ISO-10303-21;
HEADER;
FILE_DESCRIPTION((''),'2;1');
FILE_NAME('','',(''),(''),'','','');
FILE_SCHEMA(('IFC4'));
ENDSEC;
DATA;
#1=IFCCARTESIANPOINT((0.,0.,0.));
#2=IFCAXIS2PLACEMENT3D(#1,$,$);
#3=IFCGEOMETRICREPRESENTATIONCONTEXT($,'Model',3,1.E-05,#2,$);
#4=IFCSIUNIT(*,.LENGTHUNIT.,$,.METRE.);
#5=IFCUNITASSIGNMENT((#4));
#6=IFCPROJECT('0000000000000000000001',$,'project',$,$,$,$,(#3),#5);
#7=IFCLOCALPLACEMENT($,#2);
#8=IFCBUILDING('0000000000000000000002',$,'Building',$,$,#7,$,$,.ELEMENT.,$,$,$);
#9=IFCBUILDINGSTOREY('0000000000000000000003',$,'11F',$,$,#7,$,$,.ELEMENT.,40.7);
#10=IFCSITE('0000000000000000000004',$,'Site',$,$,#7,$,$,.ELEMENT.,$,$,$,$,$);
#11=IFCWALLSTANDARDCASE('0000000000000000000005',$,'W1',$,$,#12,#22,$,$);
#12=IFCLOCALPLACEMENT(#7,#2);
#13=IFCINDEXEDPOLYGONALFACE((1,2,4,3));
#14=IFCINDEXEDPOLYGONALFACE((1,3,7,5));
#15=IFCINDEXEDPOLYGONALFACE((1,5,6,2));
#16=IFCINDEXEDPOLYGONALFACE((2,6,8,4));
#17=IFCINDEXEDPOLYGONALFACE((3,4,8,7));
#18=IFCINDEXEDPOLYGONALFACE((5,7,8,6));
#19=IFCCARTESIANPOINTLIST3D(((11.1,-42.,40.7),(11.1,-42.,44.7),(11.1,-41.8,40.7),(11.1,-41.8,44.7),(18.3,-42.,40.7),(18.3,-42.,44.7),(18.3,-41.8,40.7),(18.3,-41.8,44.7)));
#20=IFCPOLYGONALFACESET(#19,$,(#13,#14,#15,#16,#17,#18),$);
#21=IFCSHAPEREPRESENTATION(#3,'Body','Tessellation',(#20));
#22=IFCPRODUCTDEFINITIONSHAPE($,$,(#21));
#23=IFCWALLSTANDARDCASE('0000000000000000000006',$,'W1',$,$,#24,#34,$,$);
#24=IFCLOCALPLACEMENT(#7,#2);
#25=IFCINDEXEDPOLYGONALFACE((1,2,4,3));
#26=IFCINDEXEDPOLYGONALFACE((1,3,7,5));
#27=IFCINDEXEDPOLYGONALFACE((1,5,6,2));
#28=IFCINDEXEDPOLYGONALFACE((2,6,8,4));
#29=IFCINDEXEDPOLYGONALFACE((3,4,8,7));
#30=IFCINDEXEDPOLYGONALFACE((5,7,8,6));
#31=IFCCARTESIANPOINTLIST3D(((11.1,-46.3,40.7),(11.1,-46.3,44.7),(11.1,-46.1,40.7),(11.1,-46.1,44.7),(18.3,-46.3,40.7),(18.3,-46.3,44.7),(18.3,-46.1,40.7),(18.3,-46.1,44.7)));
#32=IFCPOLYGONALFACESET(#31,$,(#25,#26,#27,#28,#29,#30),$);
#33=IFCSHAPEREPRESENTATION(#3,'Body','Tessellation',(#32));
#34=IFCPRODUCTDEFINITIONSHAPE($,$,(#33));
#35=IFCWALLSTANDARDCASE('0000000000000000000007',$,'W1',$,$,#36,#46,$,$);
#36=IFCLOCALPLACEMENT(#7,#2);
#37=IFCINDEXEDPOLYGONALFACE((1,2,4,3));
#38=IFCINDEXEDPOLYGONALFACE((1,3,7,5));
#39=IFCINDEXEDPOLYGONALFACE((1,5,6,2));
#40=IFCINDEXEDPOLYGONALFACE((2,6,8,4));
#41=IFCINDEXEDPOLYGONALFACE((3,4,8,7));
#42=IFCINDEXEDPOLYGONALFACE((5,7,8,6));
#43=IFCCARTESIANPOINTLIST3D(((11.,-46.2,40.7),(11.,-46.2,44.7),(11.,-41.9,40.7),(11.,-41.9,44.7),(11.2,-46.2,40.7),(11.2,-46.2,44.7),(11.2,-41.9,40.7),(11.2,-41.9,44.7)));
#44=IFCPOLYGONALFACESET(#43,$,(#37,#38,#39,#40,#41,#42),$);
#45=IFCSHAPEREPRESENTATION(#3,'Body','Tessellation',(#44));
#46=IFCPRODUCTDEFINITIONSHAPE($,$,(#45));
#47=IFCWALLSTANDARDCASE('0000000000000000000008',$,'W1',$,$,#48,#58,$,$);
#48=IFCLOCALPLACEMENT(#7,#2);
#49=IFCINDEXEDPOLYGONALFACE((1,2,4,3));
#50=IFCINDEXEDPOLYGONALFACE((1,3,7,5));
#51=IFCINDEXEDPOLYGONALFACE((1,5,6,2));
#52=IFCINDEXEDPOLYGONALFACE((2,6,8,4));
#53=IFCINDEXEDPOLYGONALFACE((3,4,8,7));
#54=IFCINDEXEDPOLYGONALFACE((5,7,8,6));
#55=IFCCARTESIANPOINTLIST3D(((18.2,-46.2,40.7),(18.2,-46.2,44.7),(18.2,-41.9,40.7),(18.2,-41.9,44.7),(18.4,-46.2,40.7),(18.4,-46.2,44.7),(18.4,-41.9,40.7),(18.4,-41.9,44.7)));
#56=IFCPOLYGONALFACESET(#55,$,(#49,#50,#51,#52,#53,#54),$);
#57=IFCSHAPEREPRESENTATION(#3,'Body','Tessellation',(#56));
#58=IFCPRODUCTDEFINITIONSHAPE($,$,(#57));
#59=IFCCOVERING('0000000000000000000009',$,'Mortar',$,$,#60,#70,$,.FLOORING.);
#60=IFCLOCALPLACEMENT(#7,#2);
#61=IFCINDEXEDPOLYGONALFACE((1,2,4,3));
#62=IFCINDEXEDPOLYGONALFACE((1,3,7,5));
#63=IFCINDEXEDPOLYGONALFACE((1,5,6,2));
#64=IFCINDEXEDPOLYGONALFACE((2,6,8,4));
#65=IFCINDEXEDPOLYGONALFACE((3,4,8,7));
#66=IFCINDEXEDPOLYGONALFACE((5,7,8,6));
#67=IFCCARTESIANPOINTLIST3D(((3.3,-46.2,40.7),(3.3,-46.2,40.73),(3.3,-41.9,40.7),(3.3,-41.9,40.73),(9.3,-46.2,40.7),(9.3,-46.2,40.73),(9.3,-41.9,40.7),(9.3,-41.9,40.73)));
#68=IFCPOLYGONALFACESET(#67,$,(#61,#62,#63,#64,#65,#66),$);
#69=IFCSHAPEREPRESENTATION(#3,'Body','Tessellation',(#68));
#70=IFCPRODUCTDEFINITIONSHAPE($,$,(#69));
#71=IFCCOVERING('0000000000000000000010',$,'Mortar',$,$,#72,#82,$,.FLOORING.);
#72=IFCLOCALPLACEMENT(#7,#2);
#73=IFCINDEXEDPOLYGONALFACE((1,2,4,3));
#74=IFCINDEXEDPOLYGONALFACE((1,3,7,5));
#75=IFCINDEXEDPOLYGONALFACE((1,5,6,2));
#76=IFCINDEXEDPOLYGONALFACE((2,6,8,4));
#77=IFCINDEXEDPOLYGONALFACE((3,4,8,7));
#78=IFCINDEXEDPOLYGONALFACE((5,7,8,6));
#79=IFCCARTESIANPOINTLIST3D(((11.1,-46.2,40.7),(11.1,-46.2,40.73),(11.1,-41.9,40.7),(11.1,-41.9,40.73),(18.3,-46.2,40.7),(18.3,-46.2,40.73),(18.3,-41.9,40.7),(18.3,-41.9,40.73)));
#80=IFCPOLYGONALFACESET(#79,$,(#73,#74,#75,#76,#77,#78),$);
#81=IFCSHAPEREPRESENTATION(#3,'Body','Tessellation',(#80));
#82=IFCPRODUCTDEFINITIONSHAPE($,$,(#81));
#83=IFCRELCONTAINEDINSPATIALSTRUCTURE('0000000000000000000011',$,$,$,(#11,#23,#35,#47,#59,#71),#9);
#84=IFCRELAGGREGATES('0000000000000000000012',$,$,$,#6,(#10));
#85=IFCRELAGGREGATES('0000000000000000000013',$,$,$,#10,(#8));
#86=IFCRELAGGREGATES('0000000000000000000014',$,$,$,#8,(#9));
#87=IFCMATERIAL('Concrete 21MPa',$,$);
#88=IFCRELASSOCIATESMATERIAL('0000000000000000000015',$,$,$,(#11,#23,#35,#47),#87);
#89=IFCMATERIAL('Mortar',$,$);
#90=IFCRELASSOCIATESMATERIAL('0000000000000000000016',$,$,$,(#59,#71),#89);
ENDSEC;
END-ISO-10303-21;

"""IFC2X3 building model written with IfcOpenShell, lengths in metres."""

from ifc_helpers import new_model, si_unit, frame, origin, origin_2d, place, context, project, spatial, rectangle, extrude, material, element, save


model = new_model("IFC2X3")

# Units and contexts
model_context = context("Model", 3, precision=1e-05, world=origin())
ifc_project = project(units=[si_unit("LENGTHUNIT", "METRE")], contexts=[model_context])

# Site, building, storey
placement = place(None, origin())
site = spatial("IfcSite", under=ifc_project, at=placement, Name="Site", CompositionType="ELEMENT")
building = spatial("IfcBuilding", under=site, at=placement, Name="Building", CompositionType="ELEMENT")
storey = spatial("IfcBuildingStorey", under=building, at=placement, Name="11F", CompositionType="ELEMENT", Elevation=40.7)

# Shared definitions
ifc_material_1 = material(Name="Concrete 21MPa")

# Walls
for number, where, name in (
    (1, (14.7, -41.9, 40.7), "W1"),
    (2, (14.7, -46.2, 40.7), "W1"),
):
    element("IfcWallStandardCase", number, at=place(None, frame(where)), inside=storey, material=ifc_material_1, Name=name, context=model_context, shape_type="SweptSolid", body=[
        extrude(rectangle(XDim=7.2, YDim=0.2, at=origin_2d()), origin(), (0.0, 0.0, 1.0), 4.0),
    ])
for number, where, name in (
    (3, (11.1, -44.05, 40.7), "W1"),
    (4, (18.3, -44.05, 40.7), "W1"),
):
    element("IfcWallStandardCase", number, at=place(None, frame(where)), inside=storey, material=ifc_material_1, Name=name, context=model_context, shape_type="SweptSolid", body=[
        extrude(rectangle(XDim=0.2, YDim=4.3, at=origin_2d()), origin(), (0.0, 0.0, 1.0), 4.0),
    ])

# Coverings
ifc_material_2 = material(Name="Mortar")
covering_1_placement = place(None, frame((6.3, -44.05, 40.7)))
element("IfcCovering", 5, at=covering_1_placement, inside=storey, material=ifc_material_2, Name="Mortar", PredefinedType="FLOORING", context=model_context, shape_type="SweptSolid", body=[
    extrude(rectangle(XDim=6.0, YDim=4.3, at=origin_2d()), origin(), (0.0, 0.0, 1.0), 0.03),
])
covering_2_placement = place(None, frame((14.7, -44.05, 40.7)))
element("IfcCovering", 6, at=covering_2_placement, inside=storey, material=ifc_material_2, Name="Mortar", PredefinedType="FLOORING", context=model_context, shape_type="SweptSolid", body=[
    extrude(rectangle(XDim=7.2, YDim=4.3, at=origin_2d()), origin(), (0.0, 0.0, 1.0), 0.03),
])

save(model, "model.ifc")
